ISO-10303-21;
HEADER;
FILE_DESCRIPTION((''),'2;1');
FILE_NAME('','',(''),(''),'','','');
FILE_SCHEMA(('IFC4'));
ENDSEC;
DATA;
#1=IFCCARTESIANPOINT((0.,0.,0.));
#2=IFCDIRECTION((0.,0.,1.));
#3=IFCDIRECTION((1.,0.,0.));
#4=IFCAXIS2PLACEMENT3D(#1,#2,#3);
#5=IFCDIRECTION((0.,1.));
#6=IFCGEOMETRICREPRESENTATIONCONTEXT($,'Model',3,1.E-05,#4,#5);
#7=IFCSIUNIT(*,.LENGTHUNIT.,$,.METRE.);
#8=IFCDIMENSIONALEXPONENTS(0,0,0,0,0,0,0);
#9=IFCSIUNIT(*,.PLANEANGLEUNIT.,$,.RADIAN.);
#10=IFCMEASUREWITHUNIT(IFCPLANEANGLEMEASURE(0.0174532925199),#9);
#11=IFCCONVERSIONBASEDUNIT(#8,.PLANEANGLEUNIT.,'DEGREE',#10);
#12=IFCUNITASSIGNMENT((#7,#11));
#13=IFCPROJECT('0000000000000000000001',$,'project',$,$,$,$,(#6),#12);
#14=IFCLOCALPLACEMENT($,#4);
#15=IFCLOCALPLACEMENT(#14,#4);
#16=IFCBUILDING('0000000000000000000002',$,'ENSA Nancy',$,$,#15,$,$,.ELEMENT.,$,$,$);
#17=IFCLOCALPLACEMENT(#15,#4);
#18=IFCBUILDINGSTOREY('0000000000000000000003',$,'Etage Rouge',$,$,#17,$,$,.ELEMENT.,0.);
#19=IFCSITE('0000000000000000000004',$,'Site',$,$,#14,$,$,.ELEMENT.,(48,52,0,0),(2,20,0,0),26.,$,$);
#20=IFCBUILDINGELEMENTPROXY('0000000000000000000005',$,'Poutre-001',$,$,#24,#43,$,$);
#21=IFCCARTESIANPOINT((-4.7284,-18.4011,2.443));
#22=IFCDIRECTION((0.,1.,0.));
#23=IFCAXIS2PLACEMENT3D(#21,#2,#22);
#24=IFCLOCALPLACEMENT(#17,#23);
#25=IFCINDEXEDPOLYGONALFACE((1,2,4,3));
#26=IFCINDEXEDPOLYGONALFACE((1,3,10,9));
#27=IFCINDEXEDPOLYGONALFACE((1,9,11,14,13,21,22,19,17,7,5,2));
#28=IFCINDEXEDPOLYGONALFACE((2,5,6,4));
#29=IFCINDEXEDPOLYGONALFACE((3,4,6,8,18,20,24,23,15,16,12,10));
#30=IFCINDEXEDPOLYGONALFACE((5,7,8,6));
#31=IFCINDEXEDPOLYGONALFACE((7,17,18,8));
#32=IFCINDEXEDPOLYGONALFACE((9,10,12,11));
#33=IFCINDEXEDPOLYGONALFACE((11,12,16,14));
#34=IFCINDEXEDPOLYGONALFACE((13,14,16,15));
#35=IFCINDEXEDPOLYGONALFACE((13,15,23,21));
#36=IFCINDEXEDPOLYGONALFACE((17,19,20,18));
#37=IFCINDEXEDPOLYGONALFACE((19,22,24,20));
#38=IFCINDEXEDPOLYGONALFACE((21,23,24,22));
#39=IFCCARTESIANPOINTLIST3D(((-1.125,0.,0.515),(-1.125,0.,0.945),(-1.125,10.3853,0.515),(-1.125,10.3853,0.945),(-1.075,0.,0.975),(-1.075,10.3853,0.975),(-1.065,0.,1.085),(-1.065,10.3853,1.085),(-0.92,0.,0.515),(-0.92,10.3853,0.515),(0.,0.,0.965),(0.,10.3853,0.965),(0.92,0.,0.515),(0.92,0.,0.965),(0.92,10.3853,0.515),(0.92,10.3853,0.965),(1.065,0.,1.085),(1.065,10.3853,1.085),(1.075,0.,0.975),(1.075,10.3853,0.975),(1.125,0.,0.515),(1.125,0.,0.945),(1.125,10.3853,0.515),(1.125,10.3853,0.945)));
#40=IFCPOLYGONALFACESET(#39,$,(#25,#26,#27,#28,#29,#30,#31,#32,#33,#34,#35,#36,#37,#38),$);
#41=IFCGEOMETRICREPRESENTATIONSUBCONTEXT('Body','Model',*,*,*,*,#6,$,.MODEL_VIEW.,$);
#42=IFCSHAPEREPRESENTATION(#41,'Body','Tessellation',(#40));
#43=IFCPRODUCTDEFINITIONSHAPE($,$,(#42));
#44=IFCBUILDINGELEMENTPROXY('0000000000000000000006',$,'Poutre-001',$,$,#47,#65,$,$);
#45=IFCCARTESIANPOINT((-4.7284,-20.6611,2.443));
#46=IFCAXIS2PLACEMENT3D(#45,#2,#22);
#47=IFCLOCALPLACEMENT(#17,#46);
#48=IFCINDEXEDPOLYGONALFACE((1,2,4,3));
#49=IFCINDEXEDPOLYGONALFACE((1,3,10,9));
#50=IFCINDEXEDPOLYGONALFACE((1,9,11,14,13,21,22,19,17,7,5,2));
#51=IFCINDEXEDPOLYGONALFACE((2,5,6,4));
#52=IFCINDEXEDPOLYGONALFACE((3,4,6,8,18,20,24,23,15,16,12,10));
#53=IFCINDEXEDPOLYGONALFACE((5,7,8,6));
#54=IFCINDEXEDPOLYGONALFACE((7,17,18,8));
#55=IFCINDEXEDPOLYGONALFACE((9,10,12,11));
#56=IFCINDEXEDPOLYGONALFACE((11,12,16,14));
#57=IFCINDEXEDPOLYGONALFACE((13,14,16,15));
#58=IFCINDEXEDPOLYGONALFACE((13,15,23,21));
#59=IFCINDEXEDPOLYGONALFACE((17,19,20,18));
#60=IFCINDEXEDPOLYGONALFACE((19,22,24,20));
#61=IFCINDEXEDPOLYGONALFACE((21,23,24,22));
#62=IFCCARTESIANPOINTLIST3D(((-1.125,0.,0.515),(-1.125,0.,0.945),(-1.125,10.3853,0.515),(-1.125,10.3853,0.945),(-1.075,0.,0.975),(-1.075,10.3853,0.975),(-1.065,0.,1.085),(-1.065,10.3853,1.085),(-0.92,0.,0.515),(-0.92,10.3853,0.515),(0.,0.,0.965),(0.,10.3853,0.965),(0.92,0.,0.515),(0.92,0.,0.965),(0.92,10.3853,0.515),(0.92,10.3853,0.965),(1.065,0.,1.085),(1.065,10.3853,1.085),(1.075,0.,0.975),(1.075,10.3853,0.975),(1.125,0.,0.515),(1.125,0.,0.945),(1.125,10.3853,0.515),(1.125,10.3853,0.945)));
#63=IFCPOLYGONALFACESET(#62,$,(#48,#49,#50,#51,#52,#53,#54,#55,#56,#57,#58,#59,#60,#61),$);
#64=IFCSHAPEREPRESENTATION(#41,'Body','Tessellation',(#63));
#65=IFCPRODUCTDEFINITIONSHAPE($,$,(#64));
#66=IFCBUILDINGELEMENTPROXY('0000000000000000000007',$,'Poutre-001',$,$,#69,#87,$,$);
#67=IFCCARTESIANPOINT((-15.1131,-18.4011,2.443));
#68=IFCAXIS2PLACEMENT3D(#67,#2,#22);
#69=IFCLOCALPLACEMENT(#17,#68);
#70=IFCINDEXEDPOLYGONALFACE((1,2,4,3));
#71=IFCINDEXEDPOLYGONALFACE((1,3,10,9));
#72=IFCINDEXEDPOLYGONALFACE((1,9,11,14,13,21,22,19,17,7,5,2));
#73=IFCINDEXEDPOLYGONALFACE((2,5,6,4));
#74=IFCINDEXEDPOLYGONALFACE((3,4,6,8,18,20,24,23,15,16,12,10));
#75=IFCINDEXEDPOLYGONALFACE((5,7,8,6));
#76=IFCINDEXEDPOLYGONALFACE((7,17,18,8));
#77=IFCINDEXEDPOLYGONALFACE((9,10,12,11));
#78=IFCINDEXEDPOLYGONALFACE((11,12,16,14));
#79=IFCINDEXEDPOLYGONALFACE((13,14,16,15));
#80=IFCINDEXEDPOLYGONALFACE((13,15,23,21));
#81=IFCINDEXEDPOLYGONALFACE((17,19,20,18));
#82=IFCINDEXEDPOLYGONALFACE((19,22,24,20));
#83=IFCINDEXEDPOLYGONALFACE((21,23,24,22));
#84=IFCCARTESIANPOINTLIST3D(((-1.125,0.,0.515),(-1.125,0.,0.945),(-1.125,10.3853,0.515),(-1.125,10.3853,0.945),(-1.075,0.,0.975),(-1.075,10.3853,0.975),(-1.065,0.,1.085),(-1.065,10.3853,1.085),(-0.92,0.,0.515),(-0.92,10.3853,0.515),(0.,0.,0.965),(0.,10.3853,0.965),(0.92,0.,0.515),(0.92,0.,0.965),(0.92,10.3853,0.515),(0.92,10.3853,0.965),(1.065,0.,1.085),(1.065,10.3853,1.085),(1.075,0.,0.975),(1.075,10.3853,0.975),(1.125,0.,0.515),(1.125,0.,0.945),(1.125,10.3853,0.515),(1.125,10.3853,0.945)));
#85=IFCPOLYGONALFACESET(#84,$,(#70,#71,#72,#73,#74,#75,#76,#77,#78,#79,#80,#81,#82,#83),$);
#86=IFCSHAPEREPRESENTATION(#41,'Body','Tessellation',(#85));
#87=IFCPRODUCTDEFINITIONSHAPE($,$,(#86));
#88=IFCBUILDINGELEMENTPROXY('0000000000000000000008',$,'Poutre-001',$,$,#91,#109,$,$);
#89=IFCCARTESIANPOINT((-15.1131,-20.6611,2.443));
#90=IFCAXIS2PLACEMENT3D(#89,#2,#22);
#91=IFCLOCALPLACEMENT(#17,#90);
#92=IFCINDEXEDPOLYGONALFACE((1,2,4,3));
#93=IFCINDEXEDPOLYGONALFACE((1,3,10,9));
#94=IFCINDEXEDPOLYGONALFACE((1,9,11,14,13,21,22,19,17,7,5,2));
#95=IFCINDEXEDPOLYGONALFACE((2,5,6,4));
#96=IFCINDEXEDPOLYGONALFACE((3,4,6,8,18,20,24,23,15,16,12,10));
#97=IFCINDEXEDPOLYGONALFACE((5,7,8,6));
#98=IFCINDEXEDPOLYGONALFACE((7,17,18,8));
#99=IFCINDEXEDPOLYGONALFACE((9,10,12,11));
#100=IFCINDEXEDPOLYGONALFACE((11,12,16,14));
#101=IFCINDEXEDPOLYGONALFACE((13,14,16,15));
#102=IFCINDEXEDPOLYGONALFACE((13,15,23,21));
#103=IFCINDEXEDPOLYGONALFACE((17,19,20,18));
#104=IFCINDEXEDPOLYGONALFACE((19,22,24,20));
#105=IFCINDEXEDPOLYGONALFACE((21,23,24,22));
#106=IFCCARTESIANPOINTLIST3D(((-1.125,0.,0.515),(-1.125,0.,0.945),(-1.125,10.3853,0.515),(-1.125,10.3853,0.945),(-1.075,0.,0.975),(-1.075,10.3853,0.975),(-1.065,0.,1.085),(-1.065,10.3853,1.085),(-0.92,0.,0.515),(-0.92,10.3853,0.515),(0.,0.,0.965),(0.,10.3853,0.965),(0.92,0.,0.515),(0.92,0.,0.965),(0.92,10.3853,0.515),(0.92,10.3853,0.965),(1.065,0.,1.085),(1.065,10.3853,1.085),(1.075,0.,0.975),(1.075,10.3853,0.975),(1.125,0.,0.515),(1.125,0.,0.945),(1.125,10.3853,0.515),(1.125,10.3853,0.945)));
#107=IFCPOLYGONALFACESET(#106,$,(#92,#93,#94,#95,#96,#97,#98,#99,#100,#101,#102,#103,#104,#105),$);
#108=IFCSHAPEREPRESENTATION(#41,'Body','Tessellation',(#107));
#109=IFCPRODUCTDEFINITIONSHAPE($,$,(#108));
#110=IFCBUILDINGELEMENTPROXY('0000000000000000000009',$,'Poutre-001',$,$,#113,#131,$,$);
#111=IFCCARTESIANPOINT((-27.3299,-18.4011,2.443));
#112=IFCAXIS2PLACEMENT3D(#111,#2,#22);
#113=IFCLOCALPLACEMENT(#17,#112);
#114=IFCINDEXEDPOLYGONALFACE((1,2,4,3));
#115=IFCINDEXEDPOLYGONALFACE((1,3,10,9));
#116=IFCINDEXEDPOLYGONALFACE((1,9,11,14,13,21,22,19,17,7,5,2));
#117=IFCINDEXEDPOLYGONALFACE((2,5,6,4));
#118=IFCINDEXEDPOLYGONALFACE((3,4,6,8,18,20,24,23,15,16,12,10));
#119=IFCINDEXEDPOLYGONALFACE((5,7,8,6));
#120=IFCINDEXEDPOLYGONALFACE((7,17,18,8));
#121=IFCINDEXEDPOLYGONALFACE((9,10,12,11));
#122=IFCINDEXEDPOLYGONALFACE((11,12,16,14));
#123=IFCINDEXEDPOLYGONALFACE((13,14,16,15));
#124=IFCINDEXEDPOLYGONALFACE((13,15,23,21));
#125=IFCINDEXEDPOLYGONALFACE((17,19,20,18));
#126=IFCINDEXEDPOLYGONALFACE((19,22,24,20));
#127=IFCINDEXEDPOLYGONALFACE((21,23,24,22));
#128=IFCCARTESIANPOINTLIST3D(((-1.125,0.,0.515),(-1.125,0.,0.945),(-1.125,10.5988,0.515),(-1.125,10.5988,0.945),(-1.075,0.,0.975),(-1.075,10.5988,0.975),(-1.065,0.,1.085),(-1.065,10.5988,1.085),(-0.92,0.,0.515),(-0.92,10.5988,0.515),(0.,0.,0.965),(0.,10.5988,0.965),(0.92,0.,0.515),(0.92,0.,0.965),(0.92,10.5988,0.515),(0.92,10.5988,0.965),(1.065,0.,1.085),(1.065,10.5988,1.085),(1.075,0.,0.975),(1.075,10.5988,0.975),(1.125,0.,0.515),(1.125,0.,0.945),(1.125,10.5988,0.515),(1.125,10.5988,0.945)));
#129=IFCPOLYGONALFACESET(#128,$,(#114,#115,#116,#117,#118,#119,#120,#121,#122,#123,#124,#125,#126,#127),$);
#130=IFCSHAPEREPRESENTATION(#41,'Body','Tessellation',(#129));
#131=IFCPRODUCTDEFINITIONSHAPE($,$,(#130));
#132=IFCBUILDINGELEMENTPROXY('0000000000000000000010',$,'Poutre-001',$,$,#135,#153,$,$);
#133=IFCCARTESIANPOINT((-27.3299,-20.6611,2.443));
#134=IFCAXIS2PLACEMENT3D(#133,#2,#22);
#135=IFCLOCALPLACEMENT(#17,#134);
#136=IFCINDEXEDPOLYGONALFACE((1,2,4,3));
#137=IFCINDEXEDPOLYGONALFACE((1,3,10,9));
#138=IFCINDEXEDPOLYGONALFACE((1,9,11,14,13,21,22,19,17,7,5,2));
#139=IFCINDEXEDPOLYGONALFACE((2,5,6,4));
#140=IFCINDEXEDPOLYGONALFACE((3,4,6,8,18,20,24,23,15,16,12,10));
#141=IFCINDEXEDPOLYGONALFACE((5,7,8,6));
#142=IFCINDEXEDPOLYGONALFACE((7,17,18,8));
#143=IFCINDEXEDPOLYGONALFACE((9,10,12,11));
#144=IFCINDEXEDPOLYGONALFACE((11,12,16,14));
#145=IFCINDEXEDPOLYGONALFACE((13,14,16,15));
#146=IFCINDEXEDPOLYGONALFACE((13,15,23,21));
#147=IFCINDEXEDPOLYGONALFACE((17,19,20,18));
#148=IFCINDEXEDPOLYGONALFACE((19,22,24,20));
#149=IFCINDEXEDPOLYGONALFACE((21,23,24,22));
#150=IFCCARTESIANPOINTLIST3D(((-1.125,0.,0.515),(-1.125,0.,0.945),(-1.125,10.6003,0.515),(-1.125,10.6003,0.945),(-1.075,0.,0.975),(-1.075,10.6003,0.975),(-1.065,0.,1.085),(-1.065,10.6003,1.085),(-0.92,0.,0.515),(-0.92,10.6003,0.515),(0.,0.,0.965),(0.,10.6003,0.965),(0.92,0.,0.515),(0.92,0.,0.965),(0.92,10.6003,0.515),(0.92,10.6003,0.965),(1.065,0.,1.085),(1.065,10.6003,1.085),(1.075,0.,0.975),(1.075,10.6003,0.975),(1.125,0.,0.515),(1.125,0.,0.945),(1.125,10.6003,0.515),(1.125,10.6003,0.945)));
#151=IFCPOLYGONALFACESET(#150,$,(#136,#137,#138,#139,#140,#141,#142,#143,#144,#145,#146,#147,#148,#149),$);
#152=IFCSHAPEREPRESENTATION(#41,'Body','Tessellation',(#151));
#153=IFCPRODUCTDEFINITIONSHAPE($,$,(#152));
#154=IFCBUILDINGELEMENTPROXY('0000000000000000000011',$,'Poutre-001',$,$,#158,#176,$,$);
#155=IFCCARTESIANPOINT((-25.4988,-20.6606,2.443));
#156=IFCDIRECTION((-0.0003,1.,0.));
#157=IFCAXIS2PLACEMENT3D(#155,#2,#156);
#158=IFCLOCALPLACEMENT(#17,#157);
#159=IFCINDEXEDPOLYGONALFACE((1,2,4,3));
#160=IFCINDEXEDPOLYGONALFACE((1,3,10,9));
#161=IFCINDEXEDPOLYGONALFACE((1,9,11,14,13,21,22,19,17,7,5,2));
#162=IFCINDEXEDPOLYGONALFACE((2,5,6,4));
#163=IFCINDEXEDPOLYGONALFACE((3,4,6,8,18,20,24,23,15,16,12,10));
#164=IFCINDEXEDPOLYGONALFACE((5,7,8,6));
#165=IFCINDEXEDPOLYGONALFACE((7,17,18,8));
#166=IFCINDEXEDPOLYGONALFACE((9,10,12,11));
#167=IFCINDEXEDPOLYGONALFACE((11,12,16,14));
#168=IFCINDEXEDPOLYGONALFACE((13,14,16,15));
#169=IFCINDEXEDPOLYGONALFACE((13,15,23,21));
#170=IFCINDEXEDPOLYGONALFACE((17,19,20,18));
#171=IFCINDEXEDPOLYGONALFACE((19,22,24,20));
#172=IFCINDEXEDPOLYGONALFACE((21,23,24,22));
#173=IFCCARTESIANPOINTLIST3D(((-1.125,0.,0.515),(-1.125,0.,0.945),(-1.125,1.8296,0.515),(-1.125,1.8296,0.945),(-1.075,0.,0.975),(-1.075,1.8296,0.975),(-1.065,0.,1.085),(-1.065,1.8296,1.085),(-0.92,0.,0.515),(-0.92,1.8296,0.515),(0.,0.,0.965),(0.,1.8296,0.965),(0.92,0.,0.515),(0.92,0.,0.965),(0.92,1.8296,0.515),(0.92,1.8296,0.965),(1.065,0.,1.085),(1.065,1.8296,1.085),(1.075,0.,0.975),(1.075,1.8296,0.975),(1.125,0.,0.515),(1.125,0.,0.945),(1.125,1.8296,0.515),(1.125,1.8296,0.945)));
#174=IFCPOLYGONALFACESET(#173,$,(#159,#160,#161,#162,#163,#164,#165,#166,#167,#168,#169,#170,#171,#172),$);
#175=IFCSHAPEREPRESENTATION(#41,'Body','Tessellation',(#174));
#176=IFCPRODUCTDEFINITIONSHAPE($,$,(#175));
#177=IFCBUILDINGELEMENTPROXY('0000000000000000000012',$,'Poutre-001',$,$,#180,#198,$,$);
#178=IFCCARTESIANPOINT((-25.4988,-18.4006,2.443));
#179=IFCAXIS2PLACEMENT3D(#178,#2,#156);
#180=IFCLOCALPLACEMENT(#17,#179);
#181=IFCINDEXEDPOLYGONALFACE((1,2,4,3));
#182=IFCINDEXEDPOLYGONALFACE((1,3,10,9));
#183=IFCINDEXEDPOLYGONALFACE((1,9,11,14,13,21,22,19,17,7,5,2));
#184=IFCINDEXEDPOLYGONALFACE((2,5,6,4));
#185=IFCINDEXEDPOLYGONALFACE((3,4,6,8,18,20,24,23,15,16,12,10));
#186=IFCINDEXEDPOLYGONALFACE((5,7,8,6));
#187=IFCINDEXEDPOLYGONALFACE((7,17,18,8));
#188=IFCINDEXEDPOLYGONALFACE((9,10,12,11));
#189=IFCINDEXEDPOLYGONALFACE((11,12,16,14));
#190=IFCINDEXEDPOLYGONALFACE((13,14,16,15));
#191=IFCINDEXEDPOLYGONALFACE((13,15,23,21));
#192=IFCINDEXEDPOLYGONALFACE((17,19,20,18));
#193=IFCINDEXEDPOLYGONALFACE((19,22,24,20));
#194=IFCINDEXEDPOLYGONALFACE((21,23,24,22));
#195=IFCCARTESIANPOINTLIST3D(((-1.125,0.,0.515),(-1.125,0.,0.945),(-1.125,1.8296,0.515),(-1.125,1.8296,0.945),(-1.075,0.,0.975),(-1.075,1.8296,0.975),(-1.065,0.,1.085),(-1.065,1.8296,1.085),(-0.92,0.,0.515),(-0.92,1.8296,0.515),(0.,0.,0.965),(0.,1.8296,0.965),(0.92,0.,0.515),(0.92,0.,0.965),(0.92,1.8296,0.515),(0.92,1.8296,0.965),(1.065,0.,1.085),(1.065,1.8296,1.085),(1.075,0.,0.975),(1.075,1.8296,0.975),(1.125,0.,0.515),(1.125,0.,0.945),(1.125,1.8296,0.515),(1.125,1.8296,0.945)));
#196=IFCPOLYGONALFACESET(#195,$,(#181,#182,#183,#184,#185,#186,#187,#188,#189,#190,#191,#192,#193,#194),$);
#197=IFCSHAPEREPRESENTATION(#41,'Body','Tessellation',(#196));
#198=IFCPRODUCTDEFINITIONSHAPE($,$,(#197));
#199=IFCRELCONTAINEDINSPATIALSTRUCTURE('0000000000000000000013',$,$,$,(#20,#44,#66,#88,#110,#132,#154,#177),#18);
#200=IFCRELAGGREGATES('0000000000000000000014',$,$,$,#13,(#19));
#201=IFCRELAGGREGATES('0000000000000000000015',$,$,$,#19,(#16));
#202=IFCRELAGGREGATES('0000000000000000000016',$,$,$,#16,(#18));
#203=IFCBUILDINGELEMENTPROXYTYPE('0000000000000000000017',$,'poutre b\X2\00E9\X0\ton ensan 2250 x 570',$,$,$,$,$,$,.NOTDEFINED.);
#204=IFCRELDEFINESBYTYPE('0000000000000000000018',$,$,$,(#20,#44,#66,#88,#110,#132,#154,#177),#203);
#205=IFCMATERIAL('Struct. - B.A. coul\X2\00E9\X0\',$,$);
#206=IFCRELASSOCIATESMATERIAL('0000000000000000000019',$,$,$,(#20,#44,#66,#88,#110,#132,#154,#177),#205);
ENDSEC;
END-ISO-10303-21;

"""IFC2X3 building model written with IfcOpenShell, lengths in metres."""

from ifc_helpers import new_model, entity, si_unit, converted_unit, direction, frame, origin_with_axes, place, context, subcontext, project, spatial, polyline, outline, extrude, material, type_object, element, save


model = new_model("IFC2X3")

# Units and contexts
model_context = context("Model", 3, precision=1e-05, world=origin_with_axes(), true_north=direction((0.0, 1.0)))
body_context = subcontext(model_context, "Body", "Model", "MODEL_VIEW")
ifc_project = project(units=[si_unit("LENGTHUNIT", "METRE"), converted_unit("PLANEANGLEUNIT", "DEGREE", entity("IfcPlaneAngleMeasure", 0.0174532925199), si_unit("PLANEANGLEUNIT", "RADIAN"), dimensions=[0, 0, 0, 0, 0, 0, 0])], contexts=[model_context])

# Site, building, storey
site_placement = place(None, origin_with_axes())
site = spatial("IfcSite", under=ifc_project, at=site_placement, Name="Site", CompositionType="ELEMENT", RefLatitude=(48, 52, 0, 0), RefLongitude=(2, 20, 0, 0), RefElevation=26.0)
building_placement = place(site_placement, origin_with_axes())
building = spatial("IfcBuilding", under=site, at=building_placement, Name="ENSA Nancy", CompositionType="ELEMENT")
storey_placement = place(building_placement, origin_with_axes())
storey = spatial("IfcBuildingStorey", under=building, at=storey_placement, Name="Etage Rouge", CompositionType="ELEMENT", Elevation=0.0)

# Building element proxies
ifc_material_1 = material(Name="Struct. - B.A. coulé")
building_element_proxy_type_1 = type_object("IfcBuildingElementProxyType", Name="poutre béton ensan 2250 x 570", PredefinedType="NOTDEFINED")
for number, where, z_axis, x_axis, name in (
    (1, (-4.7284, -18.4011, 2.443), (0.0, 0.0, 1.0), (0.0, 1.0, 0.0), "Poutre-001"),
    (2, (-4.7284, -20.6611, 2.443), (0.0, 0.0, 1.0), (0.0, 1.0, 0.0), "Poutre-001"),
    (3, (-15.1131, -18.4011, 2.443), (0.0, 0.0, 1.0), (0.0, 1.0, 0.0), "Poutre-001"),
    (4, (-15.1131, -20.6611, 2.443), (0.0, 0.0, 1.0), (0.0, 1.0, 0.0), "Poutre-001"),
):
    element("IfcBuildingElementProxy", number, at=place(storey_placement, frame(where, z_axis=z_axis, x_axis=x_axis)), inside=storey, type_object=building_element_proxy_type_1, material=ifc_material_1, Name=name, context=body_context, shape_type="SweptSolid", body=[
        extrude(outline(polyline([(-1.065, 1.085), (-1.075, 0.975), (-1.125, 0.945), (-1.125, 0.515), (-0.92, 0.515), (0.0, 0.965), (0.92, 0.965), (0.92, 0.515), (1.125, 0.515), (1.125, 0.945), (1.075, 0.975), (1.065, 1.085), (-1.065, 1.085)])), frame((0.0, 10.3853, 0.0), z_axis=(0.0, -1.0, 0.0), x_axis=(1.0, 0.0, 0.0)), (0.0, 0.0, 1.0), 10.3853),
    ])
proxy_1_placement = place(storey_placement, frame((-27.3299, -18.4011, 2.443), z_axis=(0.0, 0.0, 1.0), x_axis=(0.0, 1.0, 0.0)))
element("IfcBuildingElementProxy", 5, at=proxy_1_placement, inside=storey, type_object=building_element_proxy_type_1, material=ifc_material_1, Name="Poutre-001", context=body_context, shape_type="SweptSolid", body=[
    extrude(outline(polyline([(-1.065, 1.085), (-1.075, 0.975), (-1.125, 0.945), (-1.125, 0.515), (-0.92, 0.515), (0.0, 0.965), (0.92, 0.965), (0.92, 0.515), (1.125, 0.515), (1.125, 0.945), (1.075, 0.975), (1.065, 1.085), (-1.065, 1.085)])), frame((0.0, 10.5988, 0.0), z_axis=(0.0, -1.0, 0.0), x_axis=(1.0, 0.0, 0.0)), (0.0, 0.0, 1.0), 10.5988),
])
proxy_2_placement = place(storey_placement, frame((-27.3299, -20.6611, 2.443), z_axis=(0.0, 0.0, 1.0), x_axis=(0.0, 1.0, 0.0)))
element("IfcBuildingElementProxy", 6, at=proxy_2_placement, inside=storey, type_object=building_element_proxy_type_1, material=ifc_material_1, Name="Poutre-001", context=body_context, shape_type="SweptSolid", body=[
    extrude(outline(polyline([(-1.065, 1.085), (-1.075, 0.975), (-1.125, 0.945), (-1.125, 0.515), (-0.92, 0.515), (0.0, 0.965), (0.92, 0.965), (0.92, 0.515), (1.125, 0.515), (1.125, 0.945), (1.075, 0.975), (1.065, 1.085), (-1.065, 1.085)])), frame((0.0, 10.6003, 0.0), z_axis=(0.0, -1.0, 0.0), x_axis=(1.0, 0.0, 0.0)), (0.0, 0.0, 1.0), 10.6003),
])
for number, where, z_axis, x_axis, name in (
    (7, (-25.4988, -20.6606, 2.443), (0.0, 0.0, 1.0), (-0.0003, 1.0, 0.0), "Poutre-001"),
    (8, (-25.4988, -18.4006, 2.443), (0.0, 0.0, 1.0), (-0.0003, 1.0, 0.0), "Poutre-001"),
):
    element("IfcBuildingElementProxy", number, at=place(storey_placement, frame(where, z_axis=z_axis, x_axis=x_axis)), inside=storey, type_object=building_element_proxy_type_1, material=ifc_material_1, Name=name, context=body_context, shape_type="SweptSolid", body=[
        extrude(outline(polyline([(-1.065, 1.085), (-1.075, 0.975), (-1.125, 0.945), (-1.125, 0.515), (-0.92, 0.515), (0.0, 0.965), (0.92, 0.965), (0.92, 0.515), (1.125, 0.515), (1.125, 0.945), (1.075, 0.975), (1.065, 1.085), (-1.065, 1.085)])), frame((0.0, 1.8296, 0.0), z_axis=(0.0, -1.0, 0.0), x_axis=(1.0, 0.0, 0.0)), (0.0, 0.0, 1.0), 1.8296),
    ])

save(model, "model.ifc")
